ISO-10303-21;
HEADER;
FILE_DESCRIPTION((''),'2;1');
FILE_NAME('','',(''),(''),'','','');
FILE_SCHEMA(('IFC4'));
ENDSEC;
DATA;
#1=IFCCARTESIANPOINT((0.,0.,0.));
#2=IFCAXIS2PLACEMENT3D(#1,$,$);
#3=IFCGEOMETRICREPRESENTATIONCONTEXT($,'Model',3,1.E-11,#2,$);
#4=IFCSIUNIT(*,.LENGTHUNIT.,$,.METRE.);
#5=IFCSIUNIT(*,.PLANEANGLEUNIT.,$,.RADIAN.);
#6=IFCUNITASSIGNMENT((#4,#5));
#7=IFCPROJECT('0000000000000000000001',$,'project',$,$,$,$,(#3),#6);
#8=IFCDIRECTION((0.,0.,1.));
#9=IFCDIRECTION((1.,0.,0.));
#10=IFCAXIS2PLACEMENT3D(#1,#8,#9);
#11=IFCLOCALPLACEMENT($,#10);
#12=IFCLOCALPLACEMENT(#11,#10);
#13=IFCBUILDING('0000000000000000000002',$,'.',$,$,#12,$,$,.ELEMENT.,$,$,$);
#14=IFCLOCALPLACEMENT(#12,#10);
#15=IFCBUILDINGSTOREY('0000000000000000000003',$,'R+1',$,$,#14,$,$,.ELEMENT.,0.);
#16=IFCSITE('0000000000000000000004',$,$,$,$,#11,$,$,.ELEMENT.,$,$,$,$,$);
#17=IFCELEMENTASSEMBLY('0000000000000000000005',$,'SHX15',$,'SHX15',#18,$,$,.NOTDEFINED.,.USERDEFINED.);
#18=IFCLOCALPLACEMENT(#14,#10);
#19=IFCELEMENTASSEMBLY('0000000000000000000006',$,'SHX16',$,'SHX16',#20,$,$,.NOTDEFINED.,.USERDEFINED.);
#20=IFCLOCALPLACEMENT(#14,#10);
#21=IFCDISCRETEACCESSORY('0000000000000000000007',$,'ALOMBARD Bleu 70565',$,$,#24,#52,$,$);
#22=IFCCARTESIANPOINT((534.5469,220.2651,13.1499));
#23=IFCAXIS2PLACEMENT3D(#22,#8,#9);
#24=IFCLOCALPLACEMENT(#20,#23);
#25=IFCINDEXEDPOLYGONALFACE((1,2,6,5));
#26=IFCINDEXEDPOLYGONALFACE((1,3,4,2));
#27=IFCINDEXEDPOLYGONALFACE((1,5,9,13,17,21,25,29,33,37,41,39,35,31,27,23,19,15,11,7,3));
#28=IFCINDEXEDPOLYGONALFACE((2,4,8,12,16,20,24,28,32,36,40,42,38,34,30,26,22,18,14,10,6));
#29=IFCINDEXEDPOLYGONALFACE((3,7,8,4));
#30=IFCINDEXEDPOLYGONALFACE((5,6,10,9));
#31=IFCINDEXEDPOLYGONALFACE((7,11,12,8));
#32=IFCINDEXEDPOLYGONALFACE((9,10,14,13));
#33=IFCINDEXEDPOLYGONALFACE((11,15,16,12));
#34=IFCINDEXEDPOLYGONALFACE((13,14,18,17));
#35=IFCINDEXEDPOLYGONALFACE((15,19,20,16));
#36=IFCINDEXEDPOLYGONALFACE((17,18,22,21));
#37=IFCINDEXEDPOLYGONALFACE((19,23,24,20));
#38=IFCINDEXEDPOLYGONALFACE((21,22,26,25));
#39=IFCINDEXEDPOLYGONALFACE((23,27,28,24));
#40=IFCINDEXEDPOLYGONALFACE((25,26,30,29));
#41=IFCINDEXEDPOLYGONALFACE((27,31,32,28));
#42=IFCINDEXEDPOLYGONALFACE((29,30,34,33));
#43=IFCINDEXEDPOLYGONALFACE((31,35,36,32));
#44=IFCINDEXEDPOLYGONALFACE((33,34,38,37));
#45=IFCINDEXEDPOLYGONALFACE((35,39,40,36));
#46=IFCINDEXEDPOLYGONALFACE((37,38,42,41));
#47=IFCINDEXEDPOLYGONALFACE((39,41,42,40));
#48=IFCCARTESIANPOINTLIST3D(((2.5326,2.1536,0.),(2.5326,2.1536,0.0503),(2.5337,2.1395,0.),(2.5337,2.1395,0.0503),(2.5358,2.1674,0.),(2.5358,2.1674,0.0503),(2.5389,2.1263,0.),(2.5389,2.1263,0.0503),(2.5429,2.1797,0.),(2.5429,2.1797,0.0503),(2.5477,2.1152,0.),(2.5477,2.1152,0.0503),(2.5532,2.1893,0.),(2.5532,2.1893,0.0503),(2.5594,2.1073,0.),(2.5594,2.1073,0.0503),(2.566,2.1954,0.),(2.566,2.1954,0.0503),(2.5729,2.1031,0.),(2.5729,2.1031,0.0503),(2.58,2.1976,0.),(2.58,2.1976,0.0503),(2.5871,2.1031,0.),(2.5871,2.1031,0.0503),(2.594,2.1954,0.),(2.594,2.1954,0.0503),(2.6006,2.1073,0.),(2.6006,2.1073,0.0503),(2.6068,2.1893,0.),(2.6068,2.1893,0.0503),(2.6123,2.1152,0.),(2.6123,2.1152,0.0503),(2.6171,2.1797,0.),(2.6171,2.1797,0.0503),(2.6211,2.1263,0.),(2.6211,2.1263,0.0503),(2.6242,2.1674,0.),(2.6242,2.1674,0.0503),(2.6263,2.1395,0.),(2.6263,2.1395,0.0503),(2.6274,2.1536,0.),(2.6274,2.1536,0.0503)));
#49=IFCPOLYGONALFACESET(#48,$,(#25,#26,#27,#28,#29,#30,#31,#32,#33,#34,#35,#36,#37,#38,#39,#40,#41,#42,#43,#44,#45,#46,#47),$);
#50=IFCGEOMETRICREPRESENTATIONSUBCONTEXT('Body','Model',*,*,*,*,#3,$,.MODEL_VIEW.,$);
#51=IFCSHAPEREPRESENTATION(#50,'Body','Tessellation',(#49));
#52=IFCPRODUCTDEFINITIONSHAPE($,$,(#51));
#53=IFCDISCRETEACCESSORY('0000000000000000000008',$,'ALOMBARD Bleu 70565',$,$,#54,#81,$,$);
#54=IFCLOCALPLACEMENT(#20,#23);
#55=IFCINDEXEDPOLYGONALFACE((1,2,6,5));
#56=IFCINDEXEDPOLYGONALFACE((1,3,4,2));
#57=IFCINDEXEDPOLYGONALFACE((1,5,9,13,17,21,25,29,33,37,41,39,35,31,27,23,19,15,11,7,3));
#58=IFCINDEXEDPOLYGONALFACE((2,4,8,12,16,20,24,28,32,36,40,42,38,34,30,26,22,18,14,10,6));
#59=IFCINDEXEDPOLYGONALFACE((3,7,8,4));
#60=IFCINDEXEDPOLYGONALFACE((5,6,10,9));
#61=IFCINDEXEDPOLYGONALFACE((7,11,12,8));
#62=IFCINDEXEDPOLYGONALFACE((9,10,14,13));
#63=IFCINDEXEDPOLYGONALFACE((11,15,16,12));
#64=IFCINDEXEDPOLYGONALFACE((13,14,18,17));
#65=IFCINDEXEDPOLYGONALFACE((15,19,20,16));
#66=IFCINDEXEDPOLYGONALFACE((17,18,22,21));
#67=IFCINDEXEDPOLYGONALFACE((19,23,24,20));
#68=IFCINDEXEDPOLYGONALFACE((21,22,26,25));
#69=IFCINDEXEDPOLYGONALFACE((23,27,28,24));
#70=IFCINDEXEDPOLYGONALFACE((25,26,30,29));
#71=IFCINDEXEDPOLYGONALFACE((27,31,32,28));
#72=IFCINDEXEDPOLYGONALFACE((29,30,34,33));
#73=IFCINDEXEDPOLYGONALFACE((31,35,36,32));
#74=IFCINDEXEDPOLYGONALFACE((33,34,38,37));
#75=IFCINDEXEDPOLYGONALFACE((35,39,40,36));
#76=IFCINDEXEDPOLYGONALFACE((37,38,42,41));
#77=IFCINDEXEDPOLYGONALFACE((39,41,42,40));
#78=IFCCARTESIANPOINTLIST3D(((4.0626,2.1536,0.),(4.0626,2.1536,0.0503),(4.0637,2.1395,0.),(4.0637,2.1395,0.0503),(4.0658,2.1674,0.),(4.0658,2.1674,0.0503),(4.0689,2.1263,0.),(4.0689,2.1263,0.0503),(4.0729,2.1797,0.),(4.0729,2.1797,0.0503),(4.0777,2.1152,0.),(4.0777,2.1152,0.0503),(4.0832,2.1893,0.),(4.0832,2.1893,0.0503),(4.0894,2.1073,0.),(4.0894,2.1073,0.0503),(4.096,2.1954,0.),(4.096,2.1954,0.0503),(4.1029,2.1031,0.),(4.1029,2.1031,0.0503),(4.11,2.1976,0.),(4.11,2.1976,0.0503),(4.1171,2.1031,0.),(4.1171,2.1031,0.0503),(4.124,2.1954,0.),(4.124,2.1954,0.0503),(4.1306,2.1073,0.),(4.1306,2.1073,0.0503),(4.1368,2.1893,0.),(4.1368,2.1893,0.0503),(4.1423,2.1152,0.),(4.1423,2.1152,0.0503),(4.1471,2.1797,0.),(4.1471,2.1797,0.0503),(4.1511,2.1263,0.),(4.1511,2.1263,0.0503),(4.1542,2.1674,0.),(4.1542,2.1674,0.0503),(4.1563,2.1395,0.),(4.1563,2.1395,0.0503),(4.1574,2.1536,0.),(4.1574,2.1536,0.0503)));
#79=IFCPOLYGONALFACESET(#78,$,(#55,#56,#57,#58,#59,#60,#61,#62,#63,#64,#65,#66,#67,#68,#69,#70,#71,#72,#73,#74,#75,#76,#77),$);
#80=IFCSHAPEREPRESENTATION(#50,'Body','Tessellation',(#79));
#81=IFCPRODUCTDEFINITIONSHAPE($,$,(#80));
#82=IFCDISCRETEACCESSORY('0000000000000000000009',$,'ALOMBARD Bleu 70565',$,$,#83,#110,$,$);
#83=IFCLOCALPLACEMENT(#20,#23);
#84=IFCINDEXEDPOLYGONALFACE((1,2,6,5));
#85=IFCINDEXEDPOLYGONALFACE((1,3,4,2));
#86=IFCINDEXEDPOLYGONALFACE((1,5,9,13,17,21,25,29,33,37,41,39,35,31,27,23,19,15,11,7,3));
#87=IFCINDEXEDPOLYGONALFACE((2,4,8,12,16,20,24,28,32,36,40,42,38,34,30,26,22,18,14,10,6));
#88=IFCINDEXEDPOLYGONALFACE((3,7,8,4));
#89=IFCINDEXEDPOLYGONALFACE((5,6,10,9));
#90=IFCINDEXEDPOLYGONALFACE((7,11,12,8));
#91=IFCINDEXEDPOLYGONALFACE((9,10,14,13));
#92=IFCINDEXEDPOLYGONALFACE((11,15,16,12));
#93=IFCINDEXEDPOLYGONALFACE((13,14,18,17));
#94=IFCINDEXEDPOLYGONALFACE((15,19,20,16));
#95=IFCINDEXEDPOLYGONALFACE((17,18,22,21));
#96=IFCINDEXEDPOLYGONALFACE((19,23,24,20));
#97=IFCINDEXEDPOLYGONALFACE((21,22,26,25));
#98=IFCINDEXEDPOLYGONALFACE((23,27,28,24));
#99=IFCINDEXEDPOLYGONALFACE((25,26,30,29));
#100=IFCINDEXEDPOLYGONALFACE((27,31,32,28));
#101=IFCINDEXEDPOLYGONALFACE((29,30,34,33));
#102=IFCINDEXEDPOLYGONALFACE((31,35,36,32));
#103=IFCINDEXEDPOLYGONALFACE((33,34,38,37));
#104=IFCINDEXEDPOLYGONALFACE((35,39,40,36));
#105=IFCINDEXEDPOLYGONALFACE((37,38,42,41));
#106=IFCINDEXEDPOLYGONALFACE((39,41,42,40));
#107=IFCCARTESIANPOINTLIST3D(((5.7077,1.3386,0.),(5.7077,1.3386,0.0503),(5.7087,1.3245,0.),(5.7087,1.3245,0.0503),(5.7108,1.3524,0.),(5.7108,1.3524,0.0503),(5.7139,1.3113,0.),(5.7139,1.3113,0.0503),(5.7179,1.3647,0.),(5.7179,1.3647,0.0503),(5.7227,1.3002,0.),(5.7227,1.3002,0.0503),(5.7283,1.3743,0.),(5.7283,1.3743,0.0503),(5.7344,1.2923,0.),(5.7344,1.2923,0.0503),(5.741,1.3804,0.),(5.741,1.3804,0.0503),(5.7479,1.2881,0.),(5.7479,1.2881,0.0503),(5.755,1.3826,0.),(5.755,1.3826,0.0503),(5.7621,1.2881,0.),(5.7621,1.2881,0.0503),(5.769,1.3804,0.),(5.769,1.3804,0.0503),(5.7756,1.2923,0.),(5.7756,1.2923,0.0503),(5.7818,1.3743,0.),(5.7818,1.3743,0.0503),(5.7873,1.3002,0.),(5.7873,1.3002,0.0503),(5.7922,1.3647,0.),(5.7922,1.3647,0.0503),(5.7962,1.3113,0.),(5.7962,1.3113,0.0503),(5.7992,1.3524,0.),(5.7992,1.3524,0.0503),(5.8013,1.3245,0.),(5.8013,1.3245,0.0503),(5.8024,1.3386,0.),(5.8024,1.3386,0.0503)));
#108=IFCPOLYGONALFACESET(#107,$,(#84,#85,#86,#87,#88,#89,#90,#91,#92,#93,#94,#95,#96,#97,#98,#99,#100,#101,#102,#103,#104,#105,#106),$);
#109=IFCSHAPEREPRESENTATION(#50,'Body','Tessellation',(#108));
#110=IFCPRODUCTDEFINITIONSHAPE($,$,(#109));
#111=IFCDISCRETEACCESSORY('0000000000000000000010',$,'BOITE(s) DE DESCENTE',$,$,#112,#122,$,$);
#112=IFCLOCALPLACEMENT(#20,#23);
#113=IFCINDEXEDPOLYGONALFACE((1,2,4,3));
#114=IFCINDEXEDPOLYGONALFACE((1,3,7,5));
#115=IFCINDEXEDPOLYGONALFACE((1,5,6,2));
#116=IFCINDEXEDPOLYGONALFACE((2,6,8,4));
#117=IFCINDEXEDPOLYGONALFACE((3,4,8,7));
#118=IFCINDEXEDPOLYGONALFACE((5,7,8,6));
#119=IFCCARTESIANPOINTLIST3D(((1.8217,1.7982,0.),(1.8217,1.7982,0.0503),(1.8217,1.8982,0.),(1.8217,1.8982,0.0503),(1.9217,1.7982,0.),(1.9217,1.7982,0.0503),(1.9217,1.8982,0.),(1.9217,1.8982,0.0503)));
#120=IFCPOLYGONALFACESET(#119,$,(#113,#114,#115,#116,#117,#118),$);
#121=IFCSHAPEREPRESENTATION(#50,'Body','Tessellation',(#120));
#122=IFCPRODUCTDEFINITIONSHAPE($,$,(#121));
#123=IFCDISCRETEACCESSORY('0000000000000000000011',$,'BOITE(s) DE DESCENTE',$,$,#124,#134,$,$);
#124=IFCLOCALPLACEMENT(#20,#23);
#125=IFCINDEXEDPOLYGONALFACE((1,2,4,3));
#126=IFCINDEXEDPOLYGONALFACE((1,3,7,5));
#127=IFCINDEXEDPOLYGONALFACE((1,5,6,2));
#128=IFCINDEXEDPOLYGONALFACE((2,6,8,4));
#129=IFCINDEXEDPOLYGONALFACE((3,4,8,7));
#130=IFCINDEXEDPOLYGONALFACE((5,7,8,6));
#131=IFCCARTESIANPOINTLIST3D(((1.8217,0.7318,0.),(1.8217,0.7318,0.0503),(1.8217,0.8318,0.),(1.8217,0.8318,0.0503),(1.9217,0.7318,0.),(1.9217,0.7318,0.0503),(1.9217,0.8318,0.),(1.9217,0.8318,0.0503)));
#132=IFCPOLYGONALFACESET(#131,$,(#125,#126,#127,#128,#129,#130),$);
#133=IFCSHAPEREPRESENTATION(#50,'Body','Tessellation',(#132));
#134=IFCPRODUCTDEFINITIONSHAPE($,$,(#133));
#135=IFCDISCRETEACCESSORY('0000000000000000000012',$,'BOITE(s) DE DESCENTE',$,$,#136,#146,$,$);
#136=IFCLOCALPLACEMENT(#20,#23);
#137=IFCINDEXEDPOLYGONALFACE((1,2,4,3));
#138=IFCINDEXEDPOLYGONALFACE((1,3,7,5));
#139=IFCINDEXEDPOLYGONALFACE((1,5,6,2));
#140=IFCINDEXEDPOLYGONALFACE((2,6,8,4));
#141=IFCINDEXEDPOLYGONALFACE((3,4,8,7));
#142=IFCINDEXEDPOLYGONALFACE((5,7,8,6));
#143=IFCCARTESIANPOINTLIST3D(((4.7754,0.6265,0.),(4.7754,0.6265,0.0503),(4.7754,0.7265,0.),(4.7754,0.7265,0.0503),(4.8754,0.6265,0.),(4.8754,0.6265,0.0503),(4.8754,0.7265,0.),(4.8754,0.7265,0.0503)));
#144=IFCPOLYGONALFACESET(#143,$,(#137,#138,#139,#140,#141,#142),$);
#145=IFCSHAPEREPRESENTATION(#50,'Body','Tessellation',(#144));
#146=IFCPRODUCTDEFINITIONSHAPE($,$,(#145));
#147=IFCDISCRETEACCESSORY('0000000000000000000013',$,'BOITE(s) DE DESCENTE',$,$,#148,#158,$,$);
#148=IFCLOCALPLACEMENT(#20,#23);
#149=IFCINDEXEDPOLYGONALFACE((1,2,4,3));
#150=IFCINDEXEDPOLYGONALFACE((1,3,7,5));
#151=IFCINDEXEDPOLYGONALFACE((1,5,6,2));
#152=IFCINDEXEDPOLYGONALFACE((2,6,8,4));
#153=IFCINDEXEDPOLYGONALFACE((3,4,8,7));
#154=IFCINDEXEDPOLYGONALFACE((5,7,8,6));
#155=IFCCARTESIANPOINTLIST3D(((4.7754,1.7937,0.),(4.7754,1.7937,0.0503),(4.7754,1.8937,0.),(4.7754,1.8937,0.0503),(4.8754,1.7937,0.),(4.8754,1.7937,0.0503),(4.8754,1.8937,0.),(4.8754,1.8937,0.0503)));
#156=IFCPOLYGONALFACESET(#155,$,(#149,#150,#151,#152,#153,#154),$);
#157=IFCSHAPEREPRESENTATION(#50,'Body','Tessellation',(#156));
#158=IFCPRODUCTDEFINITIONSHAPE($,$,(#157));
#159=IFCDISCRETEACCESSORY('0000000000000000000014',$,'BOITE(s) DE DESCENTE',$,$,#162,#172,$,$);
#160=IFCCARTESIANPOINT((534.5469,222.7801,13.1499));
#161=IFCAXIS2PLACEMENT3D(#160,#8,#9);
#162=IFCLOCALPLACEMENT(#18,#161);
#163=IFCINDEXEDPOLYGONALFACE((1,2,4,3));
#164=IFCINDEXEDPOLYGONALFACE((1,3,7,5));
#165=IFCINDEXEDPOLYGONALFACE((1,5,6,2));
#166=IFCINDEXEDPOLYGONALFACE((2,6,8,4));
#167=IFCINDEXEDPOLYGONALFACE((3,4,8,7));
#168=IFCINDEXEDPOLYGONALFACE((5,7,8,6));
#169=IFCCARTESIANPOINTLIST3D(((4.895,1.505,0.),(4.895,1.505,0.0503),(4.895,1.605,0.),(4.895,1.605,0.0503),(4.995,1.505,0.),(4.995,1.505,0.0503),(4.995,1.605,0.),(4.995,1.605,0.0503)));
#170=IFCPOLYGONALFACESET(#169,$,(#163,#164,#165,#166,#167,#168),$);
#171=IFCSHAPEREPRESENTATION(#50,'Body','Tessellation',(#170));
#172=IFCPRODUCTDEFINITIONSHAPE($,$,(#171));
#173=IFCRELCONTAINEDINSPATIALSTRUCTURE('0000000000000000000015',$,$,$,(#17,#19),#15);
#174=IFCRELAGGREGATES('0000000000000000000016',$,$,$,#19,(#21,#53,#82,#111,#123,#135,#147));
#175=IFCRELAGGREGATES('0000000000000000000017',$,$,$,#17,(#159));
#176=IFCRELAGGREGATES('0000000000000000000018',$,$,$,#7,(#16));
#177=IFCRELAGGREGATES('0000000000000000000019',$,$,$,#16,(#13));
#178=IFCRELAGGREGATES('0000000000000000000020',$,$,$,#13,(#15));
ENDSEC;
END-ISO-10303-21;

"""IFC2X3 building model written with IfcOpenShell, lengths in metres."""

from ifc_helpers import new_model, si_unit, frame, frame_2d, origin, origin_with_axes, place, context, subcontext, project, spatial, polyline, circle, outline, extrude, element, aggregate, save


model = new_model("IFC2X3")

# Units and contexts
model_context = context("Model", 3, precision=1e-11, world=origin())
body_context = subcontext(model_context, "Body", "Model", "MODEL_VIEW")
ifc_project = project(units=[si_unit("LENGTHUNIT", "METRE"), si_unit("PLANEANGLEUNIT", "RADIAN")], contexts=[model_context])

# Site, building, storey
site_placement = place(None, origin_with_axes())
site = spatial("IfcSite", under=ifc_project, at=site_placement, CompositionType="ELEMENT")
building_placement = place(site_placement, origin_with_axes())
building = spatial("IfcBuilding", under=site, at=building_placement, Name=".", CompositionType="ELEMENT")
storey_placement = place(building_placement, origin_with_axes())
storey = spatial("IfcBuildingStorey", under=building, at=storey_placement, Name="R+1", CompositionType="ELEMENT", Elevation=0.0)

# Element assembly
assembly_1_placement = place(storey_placement, origin_with_axes())
assembly_1 = element("IfcElementAssembly", 1, at=assembly_1_placement, inside=storey, Name="SHX15", ObjectType="SHX15", AssemblyPlace="NOTDEFINED", PredefinedType="USERDEFINED")

# Element assembly, discrete accessories
assembly_2_placement = place(storey_placement, origin_with_axes())
assembly_2 = element("IfcElementAssembly", 2, at=assembly_2_placement, inside=storey, Name="SHX16", ObjectType="SHX16", AssemblyPlace="NOTDEFINED", PredefinedType="USERDEFINED")
discrete_accessory_1_placement = place(assembly_2_placement, frame((534.5469, 220.2651, 13.1499), z_axis=(0.0, 0.0, 1.0), x_axis=(1.0, 0.0, 0.0)))
discrete_accessory_1 = element("IfcDiscreteAccessory", 3, at=discrete_accessory_1_placement, Name="ALOMBARD Bleu 70565", context=body_context, shape_type="SweptSolid", body=[
    extrude(circle(Radius=0.0475, at=frame_2d((2.15, -2.58), x_axis=(1.0, 0.0))), frame((0.0, 0.0, 0.0), z_axis=(0.0, 0.0, 1.0), x_axis=(0.0, 1.0, 0.0)), (0.0, 0.0, 1.0), 0.0503),
])
discrete_accessory_2_placement = place(assembly_2_placement, frame((534.5469, 220.2651, 13.1499), z_axis=(0.0, 0.0, 1.0), x_axis=(1.0, 0.0, 0.0)))
discrete_accessory_2 = element("IfcDiscreteAccessory", 4, at=discrete_accessory_2_placement, Name="ALOMBARD Bleu 70565", context=body_context, shape_type="SweptSolid", body=[
    extrude(circle(Radius=0.0475, at=frame_2d((2.15, -4.11), x_axis=(1.0, 0.0))), frame((0.0, 0.0, 0.0), z_axis=(0.0, 0.0, 1.0), x_axis=(0.0, 1.0, 0.0)), (0.0, 0.0, 1.0), 0.0503),
])
discrete_accessory_3_placement = place(assembly_2_placement, frame((534.5469, 220.2651, 13.1499), z_axis=(0.0, 0.0, 1.0), x_axis=(1.0, 0.0, 0.0)))
discrete_accessory_3 = element("IfcDiscreteAccessory", 5, at=discrete_accessory_3_placement, Name="ALOMBARD Bleu 70565", context=body_context, shape_type="SweptSolid", body=[
    extrude(circle(Radius=0.0475, at=frame_2d((1.3351, -5.755), x_axis=(1.0, 0.0))), frame((0.0, 0.0, 0.0), z_axis=(0.0, 0.0, 1.0), x_axis=(0.0, 1.0, 0.0)), (0.0, 0.0, 1.0), 0.0503),
])
discrete_accessory_4_placement = place(assembly_2_placement, frame((534.5469, 220.2651, 13.1499), z_axis=(0.0, 0.0, 1.0), x_axis=(1.0, 0.0, 0.0)))
discrete_accessory_4 = element("IfcDiscreteAccessory", 6, at=discrete_accessory_4_placement, Name="BOITE(s) DE DESCENTE", context=body_context, shape_type="SweptSolid", body=[
    extrude(outline(polyline([(1.7982, -1.8217), (1.7982, -1.9217), (1.8982, -1.9217), (1.8982, -1.8217), (1.7982, -1.8217)])), frame((0.0, 0.0, 0.0), z_axis=(0.0, 0.0, 1.0), x_axis=(0.0, 1.0, 0.0)), (0.0, 0.0, 1.0), 0.0503),
])
discrete_accessory_5_placement = place(assembly_2_placement, frame((534.5469, 220.2651, 13.1499), z_axis=(0.0, 0.0, 1.0), x_axis=(1.0, 0.0, 0.0)))
discrete_accessory_5 = element("IfcDiscreteAccessory", 7, at=discrete_accessory_5_placement, Name="BOITE(s) DE DESCENTE", context=body_context, shape_type="SweptSolid", body=[
    extrude(outline(polyline([(0.7318, -1.8217), (0.7318, -1.9217), (0.8318, -1.9217), (0.8318, -1.8217), (0.7318, -1.8217)])), frame((0.0, 0.0, 0.0), z_axis=(0.0, 0.0, 1.0), x_axis=(0.0, 1.0, 0.0)), (0.0, 0.0, 1.0), 0.0503),
])
discrete_accessory_6_placement = place(assembly_2_placement, frame((534.5469, 220.2651, 13.1499), z_axis=(0.0, 0.0, 1.0), x_axis=(1.0, 0.0, 0.0)))
discrete_accessory_6 = element("IfcDiscreteAccessory", 8, at=discrete_accessory_6_placement, Name="BOITE(s) DE DESCENTE", context=body_context, shape_type="SweptSolid", body=[
    extrude(outline(polyline([(0.6265, -4.7754), (0.6265, -4.8754), (0.7265, -4.8754), (0.7265, -4.7754), (0.6265, -4.7754)])), frame((0.0, 0.0, 0.0), z_axis=(0.0, 0.0, 1.0), x_axis=(0.0, 1.0, 0.0)), (0.0, 0.0, 1.0), 0.0503),
])
discrete_accessory_7_placement = place(assembly_2_placement, frame((534.5469, 220.2651, 13.1499), z_axis=(0.0, 0.0, 1.0), x_axis=(1.0, 0.0, 0.0)))
discrete_accessory_7 = element("IfcDiscreteAccessory", 9, at=discrete_accessory_7_placement, Name="BOITE(s) DE DESCENTE", context=body_context, shape_type="SweptSolid", body=[
    extrude(outline(polyline([(1.7937, -4.7754), (1.7937, -4.8754), (1.8937, -4.8754), (1.8937, -4.7754), (1.7937, -4.7754)])), frame((0.0, 0.0, 0.0), z_axis=(0.0, 0.0, 1.0), x_axis=(0.0, 1.0, 0.0)), (0.0, 0.0, 1.0), 0.0503),
])
aggregate(assembly_2, [discrete_accessory_1, discrete_accessory_2, discrete_accessory_3, discrete_accessory_4, discrete_accessory_5, discrete_accessory_6, discrete_accessory_7])

# Discrete accessory
discrete_accessory_8_placement = place(assembly_1_placement, frame((534.5469, 222.7801, 13.1499), z_axis=(0.0, 0.0, 1.0), x_axis=(1.0, 0.0, 0.0)))
discrete_accessory_8 = element("IfcDiscreteAccessory", 10, at=discrete_accessory_8_placement, Name="BOITE(s) DE DESCENTE", context=body_context, shape_type="SweptSolid", body=[
    extrude(outline(polyline([(1.505, -4.895), (1.505, -4.995), (1.605, -4.995), (1.605, -4.895), (1.505, -4.895)])), frame((0.0, 0.0, 0.0), z_axis=(0.0, 0.0, 1.0), x_axis=(0.0, 1.0, 0.0)), (0.0, 0.0, 1.0), 0.0503),
])
aggregate(assembly_1, [discrete_accessory_8])

save(model, "model.ifc")
